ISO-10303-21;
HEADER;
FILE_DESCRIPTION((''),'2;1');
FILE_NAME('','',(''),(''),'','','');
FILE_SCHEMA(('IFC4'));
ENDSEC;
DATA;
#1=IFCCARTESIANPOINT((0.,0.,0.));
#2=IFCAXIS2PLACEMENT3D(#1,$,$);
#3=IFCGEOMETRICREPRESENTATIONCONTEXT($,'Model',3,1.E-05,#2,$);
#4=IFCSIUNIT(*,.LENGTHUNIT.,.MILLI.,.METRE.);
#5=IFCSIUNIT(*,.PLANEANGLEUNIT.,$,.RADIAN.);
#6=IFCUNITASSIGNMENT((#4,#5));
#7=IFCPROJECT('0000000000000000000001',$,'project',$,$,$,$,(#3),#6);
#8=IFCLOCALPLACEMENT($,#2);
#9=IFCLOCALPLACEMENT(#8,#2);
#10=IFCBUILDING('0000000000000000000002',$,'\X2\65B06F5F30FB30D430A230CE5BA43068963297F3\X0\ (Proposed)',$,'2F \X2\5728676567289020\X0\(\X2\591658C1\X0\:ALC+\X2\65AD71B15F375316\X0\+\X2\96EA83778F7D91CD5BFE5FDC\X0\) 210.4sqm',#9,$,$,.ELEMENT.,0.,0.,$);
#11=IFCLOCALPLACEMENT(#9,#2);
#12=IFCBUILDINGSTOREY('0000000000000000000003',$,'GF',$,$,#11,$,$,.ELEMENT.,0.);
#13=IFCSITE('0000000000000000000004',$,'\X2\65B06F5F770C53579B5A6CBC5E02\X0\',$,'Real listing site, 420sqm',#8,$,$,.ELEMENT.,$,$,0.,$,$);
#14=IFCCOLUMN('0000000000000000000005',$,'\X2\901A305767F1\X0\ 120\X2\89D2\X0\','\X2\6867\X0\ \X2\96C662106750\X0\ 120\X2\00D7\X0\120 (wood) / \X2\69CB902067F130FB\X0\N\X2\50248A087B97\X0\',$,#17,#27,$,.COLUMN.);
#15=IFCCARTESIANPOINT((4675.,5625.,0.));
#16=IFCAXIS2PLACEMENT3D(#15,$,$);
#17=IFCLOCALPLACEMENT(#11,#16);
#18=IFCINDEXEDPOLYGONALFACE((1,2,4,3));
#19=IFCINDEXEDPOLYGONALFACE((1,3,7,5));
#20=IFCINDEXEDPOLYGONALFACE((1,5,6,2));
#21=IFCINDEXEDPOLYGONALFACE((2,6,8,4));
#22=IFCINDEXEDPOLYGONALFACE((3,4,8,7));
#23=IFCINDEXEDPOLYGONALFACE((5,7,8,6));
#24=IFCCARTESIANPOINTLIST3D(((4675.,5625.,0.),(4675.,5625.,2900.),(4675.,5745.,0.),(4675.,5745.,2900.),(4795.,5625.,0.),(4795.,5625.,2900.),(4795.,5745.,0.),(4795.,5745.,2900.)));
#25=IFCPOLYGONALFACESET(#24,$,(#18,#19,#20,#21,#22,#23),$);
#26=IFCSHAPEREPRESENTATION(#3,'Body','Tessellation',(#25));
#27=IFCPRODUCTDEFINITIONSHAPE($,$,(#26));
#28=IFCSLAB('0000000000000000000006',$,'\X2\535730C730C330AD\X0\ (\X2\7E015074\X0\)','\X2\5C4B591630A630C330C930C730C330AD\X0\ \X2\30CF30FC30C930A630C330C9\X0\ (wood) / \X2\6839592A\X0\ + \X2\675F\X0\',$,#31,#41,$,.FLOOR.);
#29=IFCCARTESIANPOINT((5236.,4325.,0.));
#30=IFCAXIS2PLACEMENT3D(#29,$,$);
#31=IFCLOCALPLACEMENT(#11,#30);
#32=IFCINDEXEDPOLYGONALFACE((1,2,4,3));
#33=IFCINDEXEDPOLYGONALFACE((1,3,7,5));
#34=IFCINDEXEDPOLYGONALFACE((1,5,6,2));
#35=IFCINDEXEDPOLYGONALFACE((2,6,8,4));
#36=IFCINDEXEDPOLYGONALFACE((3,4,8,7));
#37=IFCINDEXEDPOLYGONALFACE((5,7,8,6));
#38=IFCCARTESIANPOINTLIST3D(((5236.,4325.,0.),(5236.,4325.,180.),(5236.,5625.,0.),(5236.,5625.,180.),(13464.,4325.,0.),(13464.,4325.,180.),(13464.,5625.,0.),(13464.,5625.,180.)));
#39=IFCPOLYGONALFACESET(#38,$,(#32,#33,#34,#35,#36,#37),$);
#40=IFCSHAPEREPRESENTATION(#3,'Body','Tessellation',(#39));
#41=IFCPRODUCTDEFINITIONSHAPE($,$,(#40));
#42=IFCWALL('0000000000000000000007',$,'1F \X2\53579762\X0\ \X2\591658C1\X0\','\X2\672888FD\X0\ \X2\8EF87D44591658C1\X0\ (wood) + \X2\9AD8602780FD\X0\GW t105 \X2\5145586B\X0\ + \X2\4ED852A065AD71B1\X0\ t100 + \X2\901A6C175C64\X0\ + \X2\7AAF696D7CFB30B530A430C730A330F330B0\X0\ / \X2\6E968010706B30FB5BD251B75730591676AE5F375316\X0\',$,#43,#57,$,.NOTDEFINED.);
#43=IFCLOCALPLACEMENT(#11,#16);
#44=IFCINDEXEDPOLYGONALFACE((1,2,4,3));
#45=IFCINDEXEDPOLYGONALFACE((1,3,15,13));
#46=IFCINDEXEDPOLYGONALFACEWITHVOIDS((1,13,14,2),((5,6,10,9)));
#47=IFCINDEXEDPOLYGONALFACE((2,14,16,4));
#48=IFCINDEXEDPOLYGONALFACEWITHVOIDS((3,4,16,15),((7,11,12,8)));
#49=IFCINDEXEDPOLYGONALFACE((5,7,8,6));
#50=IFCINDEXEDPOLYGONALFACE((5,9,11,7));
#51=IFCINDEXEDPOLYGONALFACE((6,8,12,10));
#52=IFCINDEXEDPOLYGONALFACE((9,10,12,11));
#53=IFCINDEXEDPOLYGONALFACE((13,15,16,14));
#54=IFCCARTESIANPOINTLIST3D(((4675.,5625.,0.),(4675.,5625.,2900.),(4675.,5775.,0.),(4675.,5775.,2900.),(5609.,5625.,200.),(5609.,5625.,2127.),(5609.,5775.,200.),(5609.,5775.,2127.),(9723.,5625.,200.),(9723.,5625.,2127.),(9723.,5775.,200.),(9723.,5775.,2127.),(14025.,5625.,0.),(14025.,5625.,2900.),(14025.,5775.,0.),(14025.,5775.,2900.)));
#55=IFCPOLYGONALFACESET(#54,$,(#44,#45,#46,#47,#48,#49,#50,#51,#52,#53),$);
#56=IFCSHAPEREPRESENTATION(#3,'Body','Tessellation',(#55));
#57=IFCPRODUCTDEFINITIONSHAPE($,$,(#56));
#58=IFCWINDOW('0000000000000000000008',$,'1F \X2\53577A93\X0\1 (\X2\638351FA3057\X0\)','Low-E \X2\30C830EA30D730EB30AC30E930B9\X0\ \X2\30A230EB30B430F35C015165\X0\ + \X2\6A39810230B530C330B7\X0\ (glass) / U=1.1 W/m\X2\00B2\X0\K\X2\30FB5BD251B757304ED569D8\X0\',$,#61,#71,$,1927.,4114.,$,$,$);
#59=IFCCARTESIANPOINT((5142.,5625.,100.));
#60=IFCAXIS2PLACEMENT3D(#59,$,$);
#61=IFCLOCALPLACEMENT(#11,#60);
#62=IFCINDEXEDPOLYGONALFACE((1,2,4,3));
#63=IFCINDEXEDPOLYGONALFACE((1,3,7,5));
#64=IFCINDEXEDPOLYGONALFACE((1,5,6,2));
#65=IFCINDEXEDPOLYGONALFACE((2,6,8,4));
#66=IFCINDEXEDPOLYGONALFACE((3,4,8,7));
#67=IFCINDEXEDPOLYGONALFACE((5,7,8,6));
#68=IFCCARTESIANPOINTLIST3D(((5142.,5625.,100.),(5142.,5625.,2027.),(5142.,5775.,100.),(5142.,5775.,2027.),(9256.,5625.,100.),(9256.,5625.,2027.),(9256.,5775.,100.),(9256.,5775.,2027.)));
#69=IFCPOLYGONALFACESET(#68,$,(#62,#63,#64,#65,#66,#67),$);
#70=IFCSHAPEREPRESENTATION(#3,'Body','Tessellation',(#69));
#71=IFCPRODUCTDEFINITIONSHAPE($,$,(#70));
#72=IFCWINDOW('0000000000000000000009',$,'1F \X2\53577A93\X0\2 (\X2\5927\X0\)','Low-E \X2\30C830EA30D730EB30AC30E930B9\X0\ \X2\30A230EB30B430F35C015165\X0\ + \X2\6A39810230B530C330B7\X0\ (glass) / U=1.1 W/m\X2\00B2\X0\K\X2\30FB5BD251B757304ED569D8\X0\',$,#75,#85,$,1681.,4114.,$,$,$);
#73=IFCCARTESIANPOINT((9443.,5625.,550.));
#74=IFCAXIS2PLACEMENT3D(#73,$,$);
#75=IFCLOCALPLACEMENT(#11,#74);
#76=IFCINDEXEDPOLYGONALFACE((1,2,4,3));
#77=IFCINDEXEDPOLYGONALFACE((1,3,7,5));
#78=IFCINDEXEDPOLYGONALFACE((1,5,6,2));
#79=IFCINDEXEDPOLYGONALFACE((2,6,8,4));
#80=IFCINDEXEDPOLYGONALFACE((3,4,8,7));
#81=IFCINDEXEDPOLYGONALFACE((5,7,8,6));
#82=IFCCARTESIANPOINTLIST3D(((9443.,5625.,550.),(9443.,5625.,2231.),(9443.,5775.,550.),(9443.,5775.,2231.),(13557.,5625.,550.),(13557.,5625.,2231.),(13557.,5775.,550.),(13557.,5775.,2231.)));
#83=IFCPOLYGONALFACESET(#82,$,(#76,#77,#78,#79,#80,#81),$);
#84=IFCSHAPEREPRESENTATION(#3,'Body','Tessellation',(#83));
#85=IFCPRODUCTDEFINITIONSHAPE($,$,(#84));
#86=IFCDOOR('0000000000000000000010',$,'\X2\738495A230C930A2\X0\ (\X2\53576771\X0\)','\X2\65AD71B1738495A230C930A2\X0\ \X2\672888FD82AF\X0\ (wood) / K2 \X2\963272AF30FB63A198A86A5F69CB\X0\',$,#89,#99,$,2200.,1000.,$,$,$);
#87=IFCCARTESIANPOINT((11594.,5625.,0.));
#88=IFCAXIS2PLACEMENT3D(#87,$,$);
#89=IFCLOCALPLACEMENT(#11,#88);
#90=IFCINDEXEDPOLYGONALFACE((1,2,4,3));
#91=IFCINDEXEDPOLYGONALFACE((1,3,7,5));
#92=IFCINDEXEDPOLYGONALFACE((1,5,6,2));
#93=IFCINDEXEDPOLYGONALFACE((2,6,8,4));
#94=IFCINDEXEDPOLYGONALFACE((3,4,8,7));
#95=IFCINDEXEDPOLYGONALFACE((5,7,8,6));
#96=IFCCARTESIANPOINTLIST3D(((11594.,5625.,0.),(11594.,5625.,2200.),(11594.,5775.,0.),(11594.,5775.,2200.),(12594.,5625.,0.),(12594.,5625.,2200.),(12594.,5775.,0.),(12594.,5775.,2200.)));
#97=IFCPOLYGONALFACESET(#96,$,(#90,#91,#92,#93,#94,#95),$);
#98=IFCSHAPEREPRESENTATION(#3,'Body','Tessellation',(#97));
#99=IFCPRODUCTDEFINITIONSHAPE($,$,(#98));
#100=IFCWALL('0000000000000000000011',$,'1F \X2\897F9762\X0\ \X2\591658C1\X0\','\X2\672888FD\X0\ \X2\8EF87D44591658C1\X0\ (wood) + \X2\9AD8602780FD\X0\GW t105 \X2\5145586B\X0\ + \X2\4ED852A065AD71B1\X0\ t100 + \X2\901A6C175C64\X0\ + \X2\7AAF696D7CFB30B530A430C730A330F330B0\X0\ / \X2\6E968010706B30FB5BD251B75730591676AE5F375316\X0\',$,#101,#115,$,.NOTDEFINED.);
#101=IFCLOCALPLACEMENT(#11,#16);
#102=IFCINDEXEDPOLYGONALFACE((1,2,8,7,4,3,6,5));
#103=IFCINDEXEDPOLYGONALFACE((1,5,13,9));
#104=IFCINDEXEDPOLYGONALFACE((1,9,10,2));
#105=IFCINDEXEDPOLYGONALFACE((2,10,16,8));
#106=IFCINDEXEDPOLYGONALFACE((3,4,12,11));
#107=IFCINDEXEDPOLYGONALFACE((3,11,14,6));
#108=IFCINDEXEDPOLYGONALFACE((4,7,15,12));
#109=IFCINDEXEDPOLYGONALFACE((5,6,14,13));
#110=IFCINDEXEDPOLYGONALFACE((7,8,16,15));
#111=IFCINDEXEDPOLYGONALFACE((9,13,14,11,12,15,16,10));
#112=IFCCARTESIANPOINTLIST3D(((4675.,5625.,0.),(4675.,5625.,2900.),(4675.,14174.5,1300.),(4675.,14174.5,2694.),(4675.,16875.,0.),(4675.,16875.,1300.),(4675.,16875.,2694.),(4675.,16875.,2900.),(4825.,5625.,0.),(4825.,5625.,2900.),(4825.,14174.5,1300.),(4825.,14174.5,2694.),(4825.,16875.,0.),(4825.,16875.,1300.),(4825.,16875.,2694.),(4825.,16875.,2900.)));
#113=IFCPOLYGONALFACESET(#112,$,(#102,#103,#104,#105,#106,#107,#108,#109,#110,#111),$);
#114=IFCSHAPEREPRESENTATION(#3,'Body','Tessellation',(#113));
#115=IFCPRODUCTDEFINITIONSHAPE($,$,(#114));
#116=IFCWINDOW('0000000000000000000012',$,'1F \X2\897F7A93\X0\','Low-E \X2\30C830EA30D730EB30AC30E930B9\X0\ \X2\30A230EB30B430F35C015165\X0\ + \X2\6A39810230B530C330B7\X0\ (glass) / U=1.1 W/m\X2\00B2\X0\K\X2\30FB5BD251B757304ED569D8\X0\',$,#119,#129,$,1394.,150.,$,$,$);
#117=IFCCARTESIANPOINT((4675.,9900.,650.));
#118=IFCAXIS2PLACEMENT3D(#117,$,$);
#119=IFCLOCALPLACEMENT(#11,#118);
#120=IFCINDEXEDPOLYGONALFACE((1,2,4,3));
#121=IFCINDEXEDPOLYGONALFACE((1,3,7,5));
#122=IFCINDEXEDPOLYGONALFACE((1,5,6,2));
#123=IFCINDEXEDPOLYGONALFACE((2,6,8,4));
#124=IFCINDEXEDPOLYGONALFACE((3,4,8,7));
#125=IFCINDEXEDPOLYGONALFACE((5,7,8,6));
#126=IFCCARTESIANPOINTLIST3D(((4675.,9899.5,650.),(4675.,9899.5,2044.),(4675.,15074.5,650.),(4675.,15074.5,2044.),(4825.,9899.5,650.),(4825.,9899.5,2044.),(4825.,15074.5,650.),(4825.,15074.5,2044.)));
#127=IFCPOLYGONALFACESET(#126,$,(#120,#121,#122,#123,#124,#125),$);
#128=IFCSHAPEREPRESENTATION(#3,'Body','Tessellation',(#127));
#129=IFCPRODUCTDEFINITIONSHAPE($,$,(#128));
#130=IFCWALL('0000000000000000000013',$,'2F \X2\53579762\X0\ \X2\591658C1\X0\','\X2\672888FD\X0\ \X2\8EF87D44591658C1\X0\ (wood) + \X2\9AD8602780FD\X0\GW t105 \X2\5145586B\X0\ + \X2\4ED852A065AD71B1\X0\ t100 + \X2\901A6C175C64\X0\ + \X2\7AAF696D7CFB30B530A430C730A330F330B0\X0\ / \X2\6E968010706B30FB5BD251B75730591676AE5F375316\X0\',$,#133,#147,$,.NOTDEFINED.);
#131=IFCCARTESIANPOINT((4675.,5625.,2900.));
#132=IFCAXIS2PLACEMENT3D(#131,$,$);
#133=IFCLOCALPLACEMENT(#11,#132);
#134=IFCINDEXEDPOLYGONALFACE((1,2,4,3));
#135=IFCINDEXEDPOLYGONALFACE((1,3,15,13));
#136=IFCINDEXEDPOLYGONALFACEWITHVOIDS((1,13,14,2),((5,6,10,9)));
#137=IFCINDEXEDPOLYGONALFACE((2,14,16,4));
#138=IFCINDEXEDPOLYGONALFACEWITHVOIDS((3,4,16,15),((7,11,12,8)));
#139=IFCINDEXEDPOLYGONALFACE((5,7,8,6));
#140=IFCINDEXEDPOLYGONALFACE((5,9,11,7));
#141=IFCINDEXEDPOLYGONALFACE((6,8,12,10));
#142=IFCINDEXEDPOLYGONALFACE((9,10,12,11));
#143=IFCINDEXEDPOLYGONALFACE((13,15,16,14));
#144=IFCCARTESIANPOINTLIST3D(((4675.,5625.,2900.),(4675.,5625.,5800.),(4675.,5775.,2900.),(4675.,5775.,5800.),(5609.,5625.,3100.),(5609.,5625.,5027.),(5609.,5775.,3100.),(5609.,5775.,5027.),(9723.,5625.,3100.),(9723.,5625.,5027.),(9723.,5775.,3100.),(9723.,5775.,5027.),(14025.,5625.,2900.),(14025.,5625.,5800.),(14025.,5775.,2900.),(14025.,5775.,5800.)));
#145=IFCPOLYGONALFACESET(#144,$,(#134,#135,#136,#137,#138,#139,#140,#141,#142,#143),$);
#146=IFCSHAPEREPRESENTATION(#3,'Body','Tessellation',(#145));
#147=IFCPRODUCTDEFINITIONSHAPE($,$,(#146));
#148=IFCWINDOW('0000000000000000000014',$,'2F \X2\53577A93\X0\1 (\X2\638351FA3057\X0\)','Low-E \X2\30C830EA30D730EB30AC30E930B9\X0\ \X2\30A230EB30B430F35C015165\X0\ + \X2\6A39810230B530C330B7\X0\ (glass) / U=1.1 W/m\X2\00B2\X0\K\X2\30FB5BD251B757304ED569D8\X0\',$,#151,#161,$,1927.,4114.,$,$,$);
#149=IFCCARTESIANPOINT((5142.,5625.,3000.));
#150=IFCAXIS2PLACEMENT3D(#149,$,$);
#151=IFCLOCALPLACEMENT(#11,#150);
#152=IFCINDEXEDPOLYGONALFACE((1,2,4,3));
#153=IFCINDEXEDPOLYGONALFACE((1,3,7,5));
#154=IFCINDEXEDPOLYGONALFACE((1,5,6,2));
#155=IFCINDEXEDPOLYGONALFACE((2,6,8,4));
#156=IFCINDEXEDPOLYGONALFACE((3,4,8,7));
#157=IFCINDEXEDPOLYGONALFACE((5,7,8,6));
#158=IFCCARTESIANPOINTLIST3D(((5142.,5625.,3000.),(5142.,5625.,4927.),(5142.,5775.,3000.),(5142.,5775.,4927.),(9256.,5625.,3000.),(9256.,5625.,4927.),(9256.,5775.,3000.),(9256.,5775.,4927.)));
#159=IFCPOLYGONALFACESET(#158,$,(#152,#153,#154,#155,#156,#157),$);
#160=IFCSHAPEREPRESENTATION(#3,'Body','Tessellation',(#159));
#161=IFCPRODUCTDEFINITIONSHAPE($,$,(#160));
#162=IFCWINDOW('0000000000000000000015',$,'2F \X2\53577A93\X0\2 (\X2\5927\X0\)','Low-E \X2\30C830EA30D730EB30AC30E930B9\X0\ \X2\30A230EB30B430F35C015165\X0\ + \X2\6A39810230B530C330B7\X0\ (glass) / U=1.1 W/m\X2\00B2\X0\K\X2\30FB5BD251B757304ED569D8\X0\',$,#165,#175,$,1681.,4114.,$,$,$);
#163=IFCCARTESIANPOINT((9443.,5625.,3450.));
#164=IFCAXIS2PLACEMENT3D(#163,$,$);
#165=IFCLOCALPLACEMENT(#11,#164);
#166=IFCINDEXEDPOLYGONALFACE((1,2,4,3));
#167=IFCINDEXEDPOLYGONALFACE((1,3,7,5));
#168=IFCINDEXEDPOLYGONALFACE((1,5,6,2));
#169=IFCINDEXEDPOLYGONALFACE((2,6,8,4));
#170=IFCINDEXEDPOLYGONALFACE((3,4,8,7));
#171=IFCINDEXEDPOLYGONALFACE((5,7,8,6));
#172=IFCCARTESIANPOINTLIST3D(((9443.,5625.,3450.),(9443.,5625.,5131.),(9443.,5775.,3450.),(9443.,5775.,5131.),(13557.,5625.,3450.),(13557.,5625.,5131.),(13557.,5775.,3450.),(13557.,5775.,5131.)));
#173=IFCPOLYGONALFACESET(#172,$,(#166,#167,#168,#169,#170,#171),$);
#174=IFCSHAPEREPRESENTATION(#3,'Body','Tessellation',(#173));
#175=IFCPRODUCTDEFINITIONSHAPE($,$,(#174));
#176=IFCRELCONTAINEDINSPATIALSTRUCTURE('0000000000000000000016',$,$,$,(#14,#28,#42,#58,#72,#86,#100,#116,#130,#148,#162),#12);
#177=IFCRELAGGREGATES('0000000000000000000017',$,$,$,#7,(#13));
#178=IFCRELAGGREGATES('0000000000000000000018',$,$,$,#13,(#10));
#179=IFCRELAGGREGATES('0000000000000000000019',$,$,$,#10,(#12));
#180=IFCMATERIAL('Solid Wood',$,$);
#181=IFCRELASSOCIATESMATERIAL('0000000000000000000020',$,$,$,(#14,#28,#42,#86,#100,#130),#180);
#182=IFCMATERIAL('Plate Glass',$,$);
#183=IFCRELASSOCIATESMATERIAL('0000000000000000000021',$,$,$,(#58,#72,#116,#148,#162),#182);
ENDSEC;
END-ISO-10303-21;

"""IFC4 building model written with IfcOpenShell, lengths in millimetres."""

from ifc_helpers import new_model, si_unit, frame, frame_2d, origin, place, context, project, spatial, rectangle, extrude, material, element, fill, save


model = new_model("IFC4")

# Units and contexts
model_context = context("Model", 3, precision=1e-05, world=origin())
ifc_project = project(units=[si_unit("LENGTHUNIT", "METRE", prefix="MILLI"), si_unit("PLANEANGLEUNIT", "RADIAN")], contexts=[model_context])

# Site, building, storey
site_placement = place(None, origin())
site = spatial("IfcSite", under=ifc_project, at=site_placement, Name="新潟県南魚沼市", ObjectType="Real listing site, 420sqm", CompositionType="ELEMENT", RefElevation=0.0)
building_placement = place(site_placement, origin())
building = spatial("IfcBuilding", under=site, at=building_placement, Name="新潟・ピアノ室と防音 (Proposed)", ObjectType="2F 在来木造(外壁:ALC+断熱強化+雪荷载重対応) 210.4sqm", CompositionType="ELEMENT", ElevationOfRefHeight=0.0, ElevationOfTerrain=0.0)
storey_placement = place(building_placement, origin())
storey = spatial("IfcBuildingStorey", under=building, at=storey_placement, Name="GF", CompositionType="ELEMENT", Elevation=0.0)

# Column
ifc_material_1 = material(Name="Solid Wood")
column_placement = place(storey_placement, frame((4675.0, 5625.0, 0.0)))
element("IfcColumn", 1, at=column_placement, inside=storey, material=ifc_material_1, Name="通し柱 120角", Description="桧 集成材 120×120 (wood) / 構造柱・N値計算", PredefinedType="COLUMN", context=model_context, shape_type="SweptSolid", body=[
    extrude(rectangle(XDim=120.0, YDim=120.0, at=frame_2d((60.0, 60.0))), frame((4675.0, 5625.0, 0.0)), (0.0, 0.0, 1.0), 2900.0),
])

# Slab
slab_1_placement = place(storey_placement, frame((5236.0, 4325.0, 0.0)))
element("IfcSlab", 2, at=slab_1_placement, inside=storey, material=ifc_material_1, Name="南デッキ (縁側)", Description="屋外ウッドデッキ ハードウッド (wood) / 根太 + 束", PredefinedType="FLOOR", context=model_context, shape_type="SweptSolid", body=[
    extrude(rectangle(XDim=8228.0, YDim=1300.0, at=frame_2d((4114.0, 650.0))), frame((5236.0, 4325.0, 0.0)), (0.0, 0.0, 1.0), 180.0),
])

# Wall, openings, windows, door
wall_1_placement = place(storey_placement, frame((4675.0, 5625.0, 0.0)))
wall_1 = element("IfcWall", 3, at=wall_1_placement, inside=storey, material=ifc_material_1, Name="1F 南面 外壁", Description="木製 軸組外壁 (wood) + 高性能GW t105 充填 + 付加断熱 t100 + 通気層 + 窯業系サイディング / 準耐火・寒冷地外皮強化", PredefinedType="NOTDEFINED", context=model_context, shape_type="SweptSolid", body=[
    extrude(rectangle(XDim=9350.0, YDim=150.0, at=frame_2d((4675.0, 75.0))), frame((4675.0, 5625.0, 0.0)), (0.0, 0.0, 1.0), 2900.0),
])
opening_1_placement = place(storey_placement, frame((5142.0, 5625.0, 100.0)))
opening_1 = element("IfcOpeningElement", 4, at=opening_1_placement, cuts=wall_1, PredefinedType="NOTDEFINED", context=model_context, shape_type="SweptSolid", body=[
    extrude(rectangle(XDim=4114.0, YDim=150.0, at=frame_2d((2057.0, 75.0))), frame((5142.0, 5625.0, 100.0)), (0.0, 0.0, 1.0), 1927.0),
])
opening_2_placement = place(storey_placement, frame((9443.0, 5625.0, 550.0)))
opening_2 = element("IfcOpeningElement", 5, at=opening_2_placement, cuts=wall_1, PredefinedType="NOTDEFINED", context=model_context, shape_type="SweptSolid", body=[
    extrude(rectangle(XDim=4114.0, YDim=150.0, at=frame_2d((2057.0, 75.0))), frame((9443.0, 5625.0, 550.0)), (0.0, 0.0, 1.0), 1681.0),
])
opening_3_placement = place(storey_placement, frame((11594.0, 5625.0, 0.0)))
opening_3 = element("IfcOpeningElement", 6, at=opening_3_placement, cuts=wall_1, PredefinedType="NOTDEFINED", context=model_context, shape_type="SweptSolid", body=[
    extrude(rectangle(XDim=1000.0, YDim=150.0, at=frame_2d((500.0, 75.0))), frame((11594.0, 5625.0, 0.0)), (0.0, 0.0, 1.0), 2200.0),
])
ifc_material_2 = material(Name="Plate Glass")
window_1_placement = place(storey_placement, frame((5142.0, 5625.0, 100.0)))
window_1 = element("IfcWindow", 7, at=window_1_placement, inside=storey, material=ifc_material_2, Name="1F 南窓1 (掃出し)", Description="Low-E トリプルガラス アルゴン封入 + 樹脂サッシ (glass) / U=1.1 W/m²K・寒冷地仕様", OverallHeight=1927.0, OverallWidth=4114.0, context=model_context, shape_type="SweptSolid", body=[
    extrude(rectangle(XDim=4114.0, YDim=150.0, at=frame_2d((2057.0, 75.0))), frame((5142.0, 5625.0, 100.0)), (0.0, 0.0, 1.0), 1927.0),
])
fill(opening_1, window_1)
window_2_placement = place(storey_placement, frame((9443.0, 5625.0, 550.0)))
window_2 = element("IfcWindow", 8, at=window_2_placement, inside=storey, material=ifc_material_2, Name="1F 南窓2 (大)", Description="Low-E トリプルガラス アルゴン封入 + 樹脂サッシ (glass) / U=1.1 W/m²K・寒冷地仕様", OverallHeight=1681.0, OverallWidth=4114.0, context=model_context, shape_type="SweptSolid", body=[
    extrude(rectangle(XDim=4114.0, YDim=150.0, at=frame_2d((2057.0, 75.0))), frame((9443.0, 5625.0, 550.0)), (0.0, 0.0, 1.0), 1681.0),
])
fill(opening_2, window_2)
door_placement = place(storey_placement, frame((11594.0, 5625.0, 0.0)))
door = element("IfcDoor", 9, at=door_placement, inside=storey, material=ifc_material_1, Name="玄関ドア (南東)", Description="断熱玄関ドア 木製芯 (wood) / K2 防犯・採風機構", OverallHeight=2200.0, OverallWidth=1000.0, context=model_context, shape_type="SweptSolid", body=[
    extrude(rectangle(XDim=1000.0, YDim=150.0, at=frame_2d((500.0, 75.0))), frame((11594.0, 5625.0, 0.0)), (0.0, 0.0, 1.0), 2200.0),
])
fill(opening_3, door)

# Wall, opening, window
wall_2_placement = place(storey_placement, frame((4675.0, 5625.0, 0.0)))
wall_2 = element("IfcWall", 10, at=wall_2_placement, inside=storey, material=ifc_material_1, Name="1F 西面 外壁", Description="木製 軸組外壁 (wood) + 高性能GW t105 充填 + 付加断熱 t100 + 通気層 + 窯業系サイディング / 準耐火・寒冷地外皮強化", PredefinedType="NOTDEFINED", context=model_context, shape_type="SweptSolid", body=[
    extrude(rectangle(XDim=150.0, YDim=11250.0, at=frame_2d((75.0, 5625.0))), frame((4675.0, 5625.0, 0.0)), (0.0, 0.0, 1.0), 2900.0),
])
opening_4_placement = place(storey_placement, frame((4675.0, 9900.0, 650.0)))
opening_4 = element("IfcOpeningElement", 11, at=opening_4_placement, cuts=wall_2, PredefinedType="NOTDEFINED", context=model_context, shape_type="SweptSolid", body=[
    extrude(rectangle(XDim=150.0, YDim=5175.0, at=frame_2d((75.0, 2587.0))), frame((4675.0, 9900.0, 650.0)), (0.0, 0.0, 1.0), 1394.0),
])
window_3_placement = place(storey_placement, frame((4675.0, 9900.0, 650.0)))
window_3 = element("IfcWindow", 12, at=window_3_placement, inside=storey, material=ifc_material_2, Name="1F 西窓", Description="Low-E トリプルガラス アルゴン封入 + 樹脂サッシ (glass) / U=1.1 W/m²K・寒冷地仕様", OverallHeight=1394.0, OverallWidth=150.0, context=model_context, shape_type="SweptSolid", body=[
    extrude(rectangle(XDim=150.0, YDim=5175.0, at=frame_2d((75.0, 2587.0))), frame((4675.0, 9900.0, 650.0)), (0.0, 0.0, 1.0), 1394.0),
])
fill(opening_4, window_3)

# Wall, openings, windows
wall_3_placement = place(storey_placement, frame((4675.0, 5625.0, 2900.0)))
wall_3 = element("IfcWall", 13, at=wall_3_placement, inside=storey, material=ifc_material_1, Name="2F 南面 外壁", Description="木製 軸組外壁 (wood) + 高性能GW t105 充填 + 付加断熱 t100 + 通気層 + 窯業系サイディング / 準耐火・寒冷地外皮強化", PredefinedType="NOTDEFINED", context=model_context, shape_type="SweptSolid", body=[
    extrude(rectangle(XDim=9350.0, YDim=150.0, at=frame_2d((4675.0, 75.0))), frame((4675.0, 5625.0, 2900.0)), (0.0, 0.0, 1.0), 2900.0),
])
opening_5_placement = place(storey_placement, frame((5142.0, 5625.0, 3000.0)))
opening_5 = element("IfcOpeningElement", 14, at=opening_5_placement, cuts=wall_3, PredefinedType="NOTDEFINED", context=model_context, shape_type="SweptSolid", body=[
    extrude(rectangle(XDim=4114.0, YDim=150.0, at=frame_2d((2057.0, 75.0))), frame((5142.0, 5625.0, 3000.0)), (0.0, 0.0, 1.0), 1927.0),
])
opening_6_placement = place(storey_placement, frame((9443.0, 5625.0, 3450.0)))
opening_6 = element("IfcOpeningElement", 15, at=opening_6_placement, cuts=wall_3, PredefinedType="NOTDEFINED", context=model_context, shape_type="SweptSolid", body=[
    extrude(rectangle(XDim=4114.0, YDim=150.0, at=frame_2d((2057.0, 75.0))), frame((9443.0, 5625.0, 3450.0)), (0.0, 0.0, 1.0), 1681.0),
])
window_4_placement = place(storey_placement, frame((5142.0, 5625.0, 3000.0)))
window_4 = element("IfcWindow", 16, at=window_4_placement, inside=storey, material=ifc_material_2, Name="2F 南窓1 (掃出し)", Description="Low-E トリプルガラス アルゴン封入 + 樹脂サッシ (glass) / U=1.1 W/m²K・寒冷地仕様", OverallHeight=1927.0, OverallWidth=4114.0, context=model_context, shape_type="SweptSolid", body=[
    extrude(rectangle(XDim=4114.0, YDim=150.0, at=frame_2d((2057.0, 75.0))), frame((5142.0, 5625.0, 3000.0)), (0.0, 0.0, 1.0), 1927.0),
])
fill(opening_5, window_4)
window_5_placement = place(storey_placement, frame((9443.0, 5625.0, 3450.0)))
window_5 = element("IfcWindow", 17, at=window_5_placement, inside=storey, material=ifc_material_2, Name="2F 南窓2 (大)", Description="Low-E トリプルガラス アルゴン封入 + 樹脂サッシ (glass) / U=1.1 W/m²K・寒冷地仕様", OverallHeight=1681.0, OverallWidth=4114.0, context=model_context, shape_type="SweptSolid", body=[
    extrude(rectangle(XDim=4114.0, YDim=150.0, at=frame_2d((2057.0, 75.0))), frame((9443.0, 5625.0, 3450.0)), (0.0, 0.0, 1.0), 1681.0),
])
fill(opening_6, window_5)

save(model, "model.ifc")
